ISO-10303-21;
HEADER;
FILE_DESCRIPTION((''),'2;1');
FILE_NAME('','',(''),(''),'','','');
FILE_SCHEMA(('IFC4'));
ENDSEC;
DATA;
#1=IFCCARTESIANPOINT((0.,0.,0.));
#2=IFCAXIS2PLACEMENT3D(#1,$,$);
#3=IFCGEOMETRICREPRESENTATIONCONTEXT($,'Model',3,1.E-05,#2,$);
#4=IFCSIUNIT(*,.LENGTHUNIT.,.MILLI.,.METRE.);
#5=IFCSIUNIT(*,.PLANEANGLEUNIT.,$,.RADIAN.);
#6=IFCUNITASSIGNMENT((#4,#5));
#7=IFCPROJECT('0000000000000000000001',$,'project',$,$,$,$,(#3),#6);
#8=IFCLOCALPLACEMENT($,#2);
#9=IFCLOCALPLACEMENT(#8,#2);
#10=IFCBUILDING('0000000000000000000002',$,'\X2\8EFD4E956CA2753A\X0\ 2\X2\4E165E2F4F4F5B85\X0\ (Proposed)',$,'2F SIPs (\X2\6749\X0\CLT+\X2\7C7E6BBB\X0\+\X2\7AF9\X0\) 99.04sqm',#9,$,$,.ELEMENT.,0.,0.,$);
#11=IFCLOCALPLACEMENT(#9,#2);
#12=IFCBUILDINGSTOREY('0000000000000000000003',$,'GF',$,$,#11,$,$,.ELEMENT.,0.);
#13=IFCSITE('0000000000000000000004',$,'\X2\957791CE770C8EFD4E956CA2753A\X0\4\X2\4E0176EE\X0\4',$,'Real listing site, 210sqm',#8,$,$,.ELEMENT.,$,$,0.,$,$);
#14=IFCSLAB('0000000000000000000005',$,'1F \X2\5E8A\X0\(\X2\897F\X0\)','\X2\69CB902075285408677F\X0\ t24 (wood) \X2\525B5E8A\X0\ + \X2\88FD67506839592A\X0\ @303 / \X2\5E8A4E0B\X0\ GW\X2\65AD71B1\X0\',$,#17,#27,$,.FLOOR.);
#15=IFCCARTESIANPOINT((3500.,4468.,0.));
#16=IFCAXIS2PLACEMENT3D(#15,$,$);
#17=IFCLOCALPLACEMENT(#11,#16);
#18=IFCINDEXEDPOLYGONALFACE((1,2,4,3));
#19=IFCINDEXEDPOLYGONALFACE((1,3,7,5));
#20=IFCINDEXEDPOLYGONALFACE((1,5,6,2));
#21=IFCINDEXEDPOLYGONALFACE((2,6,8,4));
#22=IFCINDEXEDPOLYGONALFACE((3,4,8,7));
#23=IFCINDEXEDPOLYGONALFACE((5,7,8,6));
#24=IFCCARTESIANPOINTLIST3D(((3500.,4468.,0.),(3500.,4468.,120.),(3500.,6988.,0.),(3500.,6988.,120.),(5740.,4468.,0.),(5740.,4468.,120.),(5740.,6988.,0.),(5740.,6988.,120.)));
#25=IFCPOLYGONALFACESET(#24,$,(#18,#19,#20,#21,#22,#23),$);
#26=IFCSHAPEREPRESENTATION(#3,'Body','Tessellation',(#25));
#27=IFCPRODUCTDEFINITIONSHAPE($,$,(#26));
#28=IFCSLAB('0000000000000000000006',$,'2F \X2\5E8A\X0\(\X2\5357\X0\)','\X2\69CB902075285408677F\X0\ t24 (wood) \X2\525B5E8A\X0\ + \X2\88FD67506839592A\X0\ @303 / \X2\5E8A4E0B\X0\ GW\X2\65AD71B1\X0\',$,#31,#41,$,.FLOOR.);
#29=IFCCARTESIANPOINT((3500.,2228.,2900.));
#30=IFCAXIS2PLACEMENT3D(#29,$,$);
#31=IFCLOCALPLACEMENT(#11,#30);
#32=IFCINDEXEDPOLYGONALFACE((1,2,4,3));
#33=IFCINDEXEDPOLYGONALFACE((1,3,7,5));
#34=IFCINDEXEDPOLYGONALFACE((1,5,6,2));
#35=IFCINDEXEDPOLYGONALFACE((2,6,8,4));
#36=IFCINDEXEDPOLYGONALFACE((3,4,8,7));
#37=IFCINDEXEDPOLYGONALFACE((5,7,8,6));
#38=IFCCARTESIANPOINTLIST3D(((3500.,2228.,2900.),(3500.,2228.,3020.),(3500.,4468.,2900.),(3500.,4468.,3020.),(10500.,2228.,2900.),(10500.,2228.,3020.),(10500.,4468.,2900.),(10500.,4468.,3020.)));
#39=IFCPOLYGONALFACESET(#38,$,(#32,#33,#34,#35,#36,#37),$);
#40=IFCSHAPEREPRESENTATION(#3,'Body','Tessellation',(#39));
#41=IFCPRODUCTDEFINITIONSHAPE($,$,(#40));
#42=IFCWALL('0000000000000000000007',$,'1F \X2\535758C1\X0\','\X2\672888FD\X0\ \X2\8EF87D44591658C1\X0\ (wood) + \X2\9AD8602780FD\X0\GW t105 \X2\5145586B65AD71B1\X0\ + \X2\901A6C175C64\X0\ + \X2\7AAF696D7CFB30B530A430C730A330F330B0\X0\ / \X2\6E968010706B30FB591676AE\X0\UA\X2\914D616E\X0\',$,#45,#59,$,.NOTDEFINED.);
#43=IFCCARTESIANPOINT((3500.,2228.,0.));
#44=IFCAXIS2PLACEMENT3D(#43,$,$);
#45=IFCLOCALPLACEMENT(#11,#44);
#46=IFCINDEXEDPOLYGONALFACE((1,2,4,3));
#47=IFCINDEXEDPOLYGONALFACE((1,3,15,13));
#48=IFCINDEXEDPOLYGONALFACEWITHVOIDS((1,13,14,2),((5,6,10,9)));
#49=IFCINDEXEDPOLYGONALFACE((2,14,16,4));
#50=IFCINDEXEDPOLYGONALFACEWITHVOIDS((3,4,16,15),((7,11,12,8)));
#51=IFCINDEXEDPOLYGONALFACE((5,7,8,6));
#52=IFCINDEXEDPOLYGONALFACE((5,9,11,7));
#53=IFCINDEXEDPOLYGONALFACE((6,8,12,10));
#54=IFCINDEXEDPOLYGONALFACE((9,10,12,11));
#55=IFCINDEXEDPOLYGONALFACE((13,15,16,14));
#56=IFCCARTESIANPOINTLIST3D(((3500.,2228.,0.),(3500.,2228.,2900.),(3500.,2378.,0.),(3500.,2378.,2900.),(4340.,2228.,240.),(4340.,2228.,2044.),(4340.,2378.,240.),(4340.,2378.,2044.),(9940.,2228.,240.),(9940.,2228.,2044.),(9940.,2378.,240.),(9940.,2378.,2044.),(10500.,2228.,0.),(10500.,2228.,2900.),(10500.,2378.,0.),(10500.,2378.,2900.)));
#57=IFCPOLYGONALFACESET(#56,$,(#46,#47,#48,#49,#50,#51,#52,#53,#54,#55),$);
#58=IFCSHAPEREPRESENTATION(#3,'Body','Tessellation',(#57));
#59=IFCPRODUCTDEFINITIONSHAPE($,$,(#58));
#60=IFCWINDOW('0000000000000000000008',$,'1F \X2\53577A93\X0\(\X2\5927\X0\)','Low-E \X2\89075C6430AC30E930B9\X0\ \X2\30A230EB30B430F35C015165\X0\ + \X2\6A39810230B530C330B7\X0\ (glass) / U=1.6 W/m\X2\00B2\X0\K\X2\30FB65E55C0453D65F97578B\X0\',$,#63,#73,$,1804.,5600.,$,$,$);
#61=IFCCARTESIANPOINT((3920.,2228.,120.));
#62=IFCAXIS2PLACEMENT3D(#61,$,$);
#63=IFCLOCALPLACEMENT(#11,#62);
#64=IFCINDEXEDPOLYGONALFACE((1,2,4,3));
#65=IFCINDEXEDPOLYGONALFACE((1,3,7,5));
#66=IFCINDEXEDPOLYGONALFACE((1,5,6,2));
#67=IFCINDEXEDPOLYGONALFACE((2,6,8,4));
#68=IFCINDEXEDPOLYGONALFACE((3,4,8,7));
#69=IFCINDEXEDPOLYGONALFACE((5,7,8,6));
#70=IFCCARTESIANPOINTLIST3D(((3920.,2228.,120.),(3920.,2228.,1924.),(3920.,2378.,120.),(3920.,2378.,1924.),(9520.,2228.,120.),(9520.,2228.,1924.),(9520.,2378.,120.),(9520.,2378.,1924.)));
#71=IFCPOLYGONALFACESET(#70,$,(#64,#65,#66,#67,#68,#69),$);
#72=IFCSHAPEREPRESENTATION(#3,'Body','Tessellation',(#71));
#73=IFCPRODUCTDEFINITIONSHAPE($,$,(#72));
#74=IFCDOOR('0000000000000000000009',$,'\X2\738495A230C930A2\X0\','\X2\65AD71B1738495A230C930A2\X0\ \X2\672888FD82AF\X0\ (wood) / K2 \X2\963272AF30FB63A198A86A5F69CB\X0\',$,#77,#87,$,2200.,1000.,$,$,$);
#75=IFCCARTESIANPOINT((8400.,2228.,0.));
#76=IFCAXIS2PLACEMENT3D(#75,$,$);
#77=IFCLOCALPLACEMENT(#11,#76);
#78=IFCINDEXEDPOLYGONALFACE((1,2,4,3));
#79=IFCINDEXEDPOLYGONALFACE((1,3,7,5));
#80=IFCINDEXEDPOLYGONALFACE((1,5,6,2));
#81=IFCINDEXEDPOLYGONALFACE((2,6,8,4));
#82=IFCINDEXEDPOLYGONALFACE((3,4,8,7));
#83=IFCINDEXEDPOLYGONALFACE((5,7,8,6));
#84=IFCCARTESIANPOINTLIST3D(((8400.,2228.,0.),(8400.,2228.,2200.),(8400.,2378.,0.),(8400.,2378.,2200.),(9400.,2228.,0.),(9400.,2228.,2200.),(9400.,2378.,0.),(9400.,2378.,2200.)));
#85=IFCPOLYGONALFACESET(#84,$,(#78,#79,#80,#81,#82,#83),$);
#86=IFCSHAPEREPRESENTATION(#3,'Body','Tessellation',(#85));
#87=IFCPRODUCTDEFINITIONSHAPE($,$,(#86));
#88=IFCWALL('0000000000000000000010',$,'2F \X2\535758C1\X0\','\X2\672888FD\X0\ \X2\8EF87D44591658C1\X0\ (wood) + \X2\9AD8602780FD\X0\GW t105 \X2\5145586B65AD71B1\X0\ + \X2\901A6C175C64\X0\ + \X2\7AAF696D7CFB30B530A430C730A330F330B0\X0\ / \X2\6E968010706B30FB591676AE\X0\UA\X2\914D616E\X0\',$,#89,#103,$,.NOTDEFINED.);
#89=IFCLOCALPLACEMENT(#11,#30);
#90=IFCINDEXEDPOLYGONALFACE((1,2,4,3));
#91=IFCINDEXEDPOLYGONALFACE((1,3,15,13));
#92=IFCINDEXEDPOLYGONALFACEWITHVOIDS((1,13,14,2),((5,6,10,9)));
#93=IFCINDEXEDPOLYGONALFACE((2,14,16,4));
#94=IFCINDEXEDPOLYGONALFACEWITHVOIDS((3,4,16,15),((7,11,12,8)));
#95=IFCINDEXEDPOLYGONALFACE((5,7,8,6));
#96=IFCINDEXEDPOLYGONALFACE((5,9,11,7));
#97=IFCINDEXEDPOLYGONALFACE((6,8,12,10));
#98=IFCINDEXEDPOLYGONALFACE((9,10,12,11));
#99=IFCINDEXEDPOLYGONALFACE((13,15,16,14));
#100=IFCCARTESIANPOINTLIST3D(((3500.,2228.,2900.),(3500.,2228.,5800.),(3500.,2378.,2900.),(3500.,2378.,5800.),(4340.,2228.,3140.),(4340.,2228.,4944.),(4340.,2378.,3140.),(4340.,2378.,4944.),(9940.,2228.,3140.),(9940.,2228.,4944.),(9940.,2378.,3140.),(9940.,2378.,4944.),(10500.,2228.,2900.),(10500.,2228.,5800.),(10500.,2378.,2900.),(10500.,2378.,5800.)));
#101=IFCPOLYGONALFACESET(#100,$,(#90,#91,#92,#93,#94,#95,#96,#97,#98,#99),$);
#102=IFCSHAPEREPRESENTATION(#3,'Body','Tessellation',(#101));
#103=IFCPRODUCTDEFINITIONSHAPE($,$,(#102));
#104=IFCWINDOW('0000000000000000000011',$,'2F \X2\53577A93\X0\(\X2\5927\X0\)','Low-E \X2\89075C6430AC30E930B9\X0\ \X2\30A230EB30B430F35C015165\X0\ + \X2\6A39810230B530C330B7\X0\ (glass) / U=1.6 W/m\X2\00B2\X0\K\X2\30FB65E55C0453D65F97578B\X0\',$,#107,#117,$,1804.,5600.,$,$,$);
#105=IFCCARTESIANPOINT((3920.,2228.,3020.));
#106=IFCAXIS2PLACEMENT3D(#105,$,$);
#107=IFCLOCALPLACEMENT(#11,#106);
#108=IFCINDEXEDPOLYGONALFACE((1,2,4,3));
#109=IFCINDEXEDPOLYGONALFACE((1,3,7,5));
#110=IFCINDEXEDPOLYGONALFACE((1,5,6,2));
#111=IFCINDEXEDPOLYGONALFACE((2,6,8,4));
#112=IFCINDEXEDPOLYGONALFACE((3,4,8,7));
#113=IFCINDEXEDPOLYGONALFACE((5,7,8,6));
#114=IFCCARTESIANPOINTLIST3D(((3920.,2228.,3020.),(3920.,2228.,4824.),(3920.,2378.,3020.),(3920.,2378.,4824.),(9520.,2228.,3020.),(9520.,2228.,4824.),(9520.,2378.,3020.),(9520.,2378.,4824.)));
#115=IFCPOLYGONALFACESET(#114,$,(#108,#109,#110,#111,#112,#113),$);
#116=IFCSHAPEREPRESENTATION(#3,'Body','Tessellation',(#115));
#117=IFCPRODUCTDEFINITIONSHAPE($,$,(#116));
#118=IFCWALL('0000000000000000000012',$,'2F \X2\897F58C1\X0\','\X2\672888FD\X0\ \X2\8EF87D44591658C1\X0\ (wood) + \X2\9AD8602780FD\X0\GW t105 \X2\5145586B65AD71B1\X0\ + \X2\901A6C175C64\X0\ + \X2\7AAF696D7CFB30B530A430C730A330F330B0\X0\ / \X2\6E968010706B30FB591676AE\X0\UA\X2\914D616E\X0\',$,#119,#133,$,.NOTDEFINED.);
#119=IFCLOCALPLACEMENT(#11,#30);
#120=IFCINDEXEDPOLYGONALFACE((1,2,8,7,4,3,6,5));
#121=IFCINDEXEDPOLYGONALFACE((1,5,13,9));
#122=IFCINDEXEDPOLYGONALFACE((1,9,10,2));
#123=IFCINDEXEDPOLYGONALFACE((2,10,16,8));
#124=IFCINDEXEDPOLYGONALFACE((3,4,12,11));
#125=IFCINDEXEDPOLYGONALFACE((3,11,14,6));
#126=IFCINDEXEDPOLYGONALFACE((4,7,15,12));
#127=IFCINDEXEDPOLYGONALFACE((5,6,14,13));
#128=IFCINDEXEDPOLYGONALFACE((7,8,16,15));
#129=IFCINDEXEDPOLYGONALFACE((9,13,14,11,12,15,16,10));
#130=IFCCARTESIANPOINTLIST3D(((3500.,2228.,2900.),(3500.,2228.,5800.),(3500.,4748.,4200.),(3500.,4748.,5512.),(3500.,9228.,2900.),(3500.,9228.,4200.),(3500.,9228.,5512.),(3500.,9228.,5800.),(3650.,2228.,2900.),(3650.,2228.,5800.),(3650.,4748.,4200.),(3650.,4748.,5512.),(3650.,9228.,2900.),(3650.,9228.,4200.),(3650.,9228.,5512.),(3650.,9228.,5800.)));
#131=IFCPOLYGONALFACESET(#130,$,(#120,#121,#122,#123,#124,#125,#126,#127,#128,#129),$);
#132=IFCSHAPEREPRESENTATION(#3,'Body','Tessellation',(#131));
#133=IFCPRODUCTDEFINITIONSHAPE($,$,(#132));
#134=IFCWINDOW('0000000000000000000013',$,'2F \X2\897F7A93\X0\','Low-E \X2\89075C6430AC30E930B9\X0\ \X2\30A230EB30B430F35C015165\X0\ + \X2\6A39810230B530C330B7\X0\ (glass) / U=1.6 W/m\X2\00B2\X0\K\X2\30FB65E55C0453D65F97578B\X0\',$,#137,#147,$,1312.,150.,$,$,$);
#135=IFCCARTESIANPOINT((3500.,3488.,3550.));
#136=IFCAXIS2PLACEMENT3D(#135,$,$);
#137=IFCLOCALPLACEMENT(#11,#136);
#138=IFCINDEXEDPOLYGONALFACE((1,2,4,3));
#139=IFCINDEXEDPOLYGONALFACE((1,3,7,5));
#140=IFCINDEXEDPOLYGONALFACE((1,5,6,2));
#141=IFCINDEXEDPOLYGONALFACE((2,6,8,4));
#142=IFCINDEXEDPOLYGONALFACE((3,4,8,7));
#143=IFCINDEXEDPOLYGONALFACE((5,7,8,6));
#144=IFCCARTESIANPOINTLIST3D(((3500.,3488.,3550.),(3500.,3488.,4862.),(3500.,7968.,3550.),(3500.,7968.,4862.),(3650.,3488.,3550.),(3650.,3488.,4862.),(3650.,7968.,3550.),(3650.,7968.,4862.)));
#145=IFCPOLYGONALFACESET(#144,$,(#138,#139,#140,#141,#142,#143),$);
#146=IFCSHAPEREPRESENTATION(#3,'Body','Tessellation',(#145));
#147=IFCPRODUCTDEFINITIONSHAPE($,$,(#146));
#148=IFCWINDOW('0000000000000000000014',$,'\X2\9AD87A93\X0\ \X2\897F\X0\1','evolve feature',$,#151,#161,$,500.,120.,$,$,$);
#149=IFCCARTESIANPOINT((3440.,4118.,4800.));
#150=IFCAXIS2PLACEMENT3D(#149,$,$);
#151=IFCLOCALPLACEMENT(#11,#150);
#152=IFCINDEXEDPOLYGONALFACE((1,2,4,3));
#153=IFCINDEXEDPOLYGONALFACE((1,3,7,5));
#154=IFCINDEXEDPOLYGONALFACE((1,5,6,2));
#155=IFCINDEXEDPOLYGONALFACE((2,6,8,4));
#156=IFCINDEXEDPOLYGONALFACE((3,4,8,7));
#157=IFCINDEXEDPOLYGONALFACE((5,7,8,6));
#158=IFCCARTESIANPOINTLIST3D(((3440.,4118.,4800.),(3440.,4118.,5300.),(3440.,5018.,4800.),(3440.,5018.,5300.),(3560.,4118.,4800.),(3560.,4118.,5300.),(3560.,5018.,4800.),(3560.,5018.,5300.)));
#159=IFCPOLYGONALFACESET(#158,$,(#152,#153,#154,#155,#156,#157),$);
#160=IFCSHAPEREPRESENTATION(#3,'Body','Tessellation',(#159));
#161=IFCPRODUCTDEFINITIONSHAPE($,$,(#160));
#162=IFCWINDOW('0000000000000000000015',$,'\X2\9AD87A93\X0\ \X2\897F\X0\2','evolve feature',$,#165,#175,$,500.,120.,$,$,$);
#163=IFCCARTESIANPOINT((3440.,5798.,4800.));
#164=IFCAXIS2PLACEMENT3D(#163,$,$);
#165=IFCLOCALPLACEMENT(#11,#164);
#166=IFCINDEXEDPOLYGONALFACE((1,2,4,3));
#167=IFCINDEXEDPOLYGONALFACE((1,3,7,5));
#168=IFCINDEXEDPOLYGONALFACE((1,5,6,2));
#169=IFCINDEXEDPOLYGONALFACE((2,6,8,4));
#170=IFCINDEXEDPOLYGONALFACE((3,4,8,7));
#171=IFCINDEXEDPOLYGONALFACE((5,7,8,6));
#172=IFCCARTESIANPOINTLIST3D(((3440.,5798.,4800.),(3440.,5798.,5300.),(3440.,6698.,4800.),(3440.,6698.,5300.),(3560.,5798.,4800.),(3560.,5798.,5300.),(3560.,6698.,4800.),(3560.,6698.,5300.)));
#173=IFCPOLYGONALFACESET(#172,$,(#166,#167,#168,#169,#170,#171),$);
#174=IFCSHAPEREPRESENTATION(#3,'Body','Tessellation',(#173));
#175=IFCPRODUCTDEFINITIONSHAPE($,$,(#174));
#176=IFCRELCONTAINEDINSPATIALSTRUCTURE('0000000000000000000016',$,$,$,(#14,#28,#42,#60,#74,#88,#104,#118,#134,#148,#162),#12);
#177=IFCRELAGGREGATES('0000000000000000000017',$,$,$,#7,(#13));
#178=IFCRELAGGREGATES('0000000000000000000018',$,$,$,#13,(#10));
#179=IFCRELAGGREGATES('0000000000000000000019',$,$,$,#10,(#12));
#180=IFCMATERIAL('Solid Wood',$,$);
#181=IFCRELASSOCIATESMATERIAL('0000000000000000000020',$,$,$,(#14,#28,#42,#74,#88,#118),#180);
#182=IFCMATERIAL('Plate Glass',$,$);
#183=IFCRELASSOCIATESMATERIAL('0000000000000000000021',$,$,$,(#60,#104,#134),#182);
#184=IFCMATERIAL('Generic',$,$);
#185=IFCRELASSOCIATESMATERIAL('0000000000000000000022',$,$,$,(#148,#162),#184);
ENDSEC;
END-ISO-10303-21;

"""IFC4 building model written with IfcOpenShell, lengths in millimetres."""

from ifc_helpers import new_model, si_unit, frame, frame_2d, origin, place, context, project, spatial, rectangle, extrude, material, element, fill, save


model = new_model("IFC4")

# Units and contexts
model_context = context("Model", 3, precision=1e-05, world=origin())
ifc_project = project(units=[si_unit("LENGTHUNIT", "METRE", prefix="MILLI"), si_unit("PLANEANGLEUNIT", "RADIAN")], contexts=[model_context])

# Site, building, storey
site_placement = place(None, origin())
site = spatial("IfcSite", under=ifc_project, at=site_placement, Name="長野県軽井沢町4丁目4", ObjectType="Real listing site, 210sqm", CompositionType="ELEMENT", RefElevation=0.0)
building_placement = place(site_placement, origin())
building = spatial("IfcBuilding", under=site, at=building_placement, Name="軽井沢町 2世帯住宅 (Proposed)", ObjectType="2F SIPs (杉CLT+籾殻+竹) 99.04sqm", CompositionType="ELEMENT", ElevationOfRefHeight=0.0, ElevationOfTerrain=0.0)
storey_placement = place(building_placement, origin())
storey = spatial("IfcBuildingStorey", under=building, at=storey_placement, Name="GF", CompositionType="ELEMENT", Elevation=0.0)

# Slabs
ifc_material_1 = material(Name="Solid Wood")
slab_1_placement = place(storey_placement, frame((3500.0, 4468.0, 0.0)))
element("IfcSlab", 1, at=slab_1_placement, inside=storey, material=ifc_material_1, Name="1F 床(西)", Description="構造用合板 t24 (wood) 剛床 + 製材根太 @303 / 床下 GW断熱", PredefinedType="FLOOR", context=model_context, shape_type="SweptSolid", body=[
    extrude(rectangle(XDim=2240.0, YDim=2520.0, at=frame_2d((1120.0, 1260.0))), frame((3500.0, 4468.0, 0.0)), (0.0, 0.0, 1.0), 120.0),
])
slab_2_placement = place(storey_placement, frame((3500.0, 2228.0, 2900.0)))
element("IfcSlab", 2, at=slab_2_placement, inside=storey, material=ifc_material_1, Name="2F 床(南)", Description="構造用合板 t24 (wood) 剛床 + 製材根太 @303 / 床下 GW断熱", PredefinedType="FLOOR", context=model_context, shape_type="SweptSolid", body=[
    extrude(rectangle(XDim=7000.0, YDim=2240.0, at=frame_2d((3500.0, 1120.0))), frame((3500.0, 2228.0, 2900.0)), (0.0, 0.0, 1.0), 120.0),
])
ifc_material_2 = material(Name="Generic")

# Wall, openings, window, door
wall_1_placement = place(storey_placement, frame((3500.0, 2228.0, 0.0)))
wall_1 = element("IfcWall", 3, at=wall_1_placement, inside=storey, material=ifc_material_1, Name="1F 南壁", Description="木製 軸組外壁 (wood) + 高性能GW t105 充填断熱 + 通気層 + 窯業系サイディング / 準耐火・外皮UA配慮", PredefinedType="NOTDEFINED", context=model_context, shape_type="SweptSolid", body=[
    extrude(rectangle(XDim=7000.0, YDim=150.0, at=frame_2d((3500.0, 75.0))), frame((3500.0, 2228.0, 0.0)), (0.0, 0.0, 1.0), 2900.0),
])
opening_1_placement = place(storey_placement, frame((3920.0, 2228.0, 120.0)))
opening_1 = element("IfcOpeningElement", 4, at=opening_1_placement, cuts=wall_1, PredefinedType="NOTDEFINED", context=model_context, shape_type="SweptSolid", body=[
    extrude(rectangle(XDim=5600.0, YDim=150.0, at=frame_2d((2800.0, 75.0))), frame((3920.0, 2228.0, 120.0)), (0.0, 0.0, 1.0), 1804.0),
])
opening_2_placement = place(storey_placement, frame((8400.0, 2228.0, 0.0)))
opening_2 = element("IfcOpeningElement", 5, at=opening_2_placement, cuts=wall_1, PredefinedType="NOTDEFINED", context=model_context, shape_type="SweptSolid", body=[
    extrude(rectangle(XDim=1000.0, YDim=150.0, at=frame_2d((500.0, 75.0))), frame((8400.0, 2228.0, 0.0)), (0.0, 0.0, 1.0), 2200.0),
])
ifc_material_3 = material(Name="Plate Glass")
window_1_placement = place(storey_placement, frame((3920.0, 2228.0, 120.0)))
window_1 = element("IfcWindow", 6, at=window_1_placement, inside=storey, material=ifc_material_3, Name="1F 南窓(大)", Description="Low-E 複層ガラス アルゴン封入 + 樹脂サッシ (glass) / U=1.6 W/m²K・日射取得型", OverallHeight=1804.0, OverallWidth=5600.0, context=model_context, shape_type="SweptSolid", body=[
    extrude(rectangle(XDim=5600.0, YDim=150.0, at=frame_2d((2800.0, 75.0))), frame((3920.0, 2228.0, 120.0)), (0.0, 0.0, 1.0), 1804.0),
])
fill(opening_1, window_1)
door_placement = place(storey_placement, frame((8400.0, 2228.0, 0.0)))
door = element("IfcDoor", 7, at=door_placement, inside=storey, material=ifc_material_1, Name="玄関ドア", Description="断熱玄関ドア 木製芯 (wood) / K2 防犯・採風機構", OverallHeight=2200.0, OverallWidth=1000.0, context=model_context, shape_type="SweptSolid", body=[
    extrude(rectangle(XDim=1000.0, YDim=150.0, at=frame_2d((500.0, 75.0))), frame((8400.0, 2228.0, 0.0)), (0.0, 0.0, 1.0), 2200.0),
])
fill(opening_2, door)

# Wall, opening, window
wall_2_placement = place(storey_placement, frame((3500.0, 2228.0, 2900.0)))
wall_2 = element("IfcWall", 8, at=wall_2_placement, inside=storey, material=ifc_material_1, Name="2F 南壁", Description="木製 軸組外壁 (wood) + 高性能GW t105 充填断熱 + 通気層 + 窯業系サイディング / 準耐火・外皮UA配慮", PredefinedType="NOTDEFINED", context=model_context, shape_type="SweptSolid", body=[
    extrude(rectangle(XDim=7000.0, YDim=150.0, at=frame_2d((3500.0, 75.0))), frame((3500.0, 2228.0, 2900.0)), (0.0, 0.0, 1.0), 2900.0),
])
opening_3_placement = place(storey_placement, frame((3920.0, 2228.0, 3020.0)))
opening_3 = element("IfcOpeningElement", 9, at=opening_3_placement, cuts=wall_2, PredefinedType="NOTDEFINED", context=model_context, shape_type="SweptSolid", body=[
    extrude(rectangle(XDim=5600.0, YDim=150.0, at=frame_2d((2800.0, 75.0))), frame((3920.0, 2228.0, 3020.0)), (0.0, 0.0, 1.0), 1804.0),
])
window_2_placement = place(storey_placement, frame((3920.0, 2228.0, 3020.0)))
window_2 = element("IfcWindow", 10, at=window_2_placement, inside=storey, material=ifc_material_3, Name="2F 南窓(大)", Description="Low-E 複層ガラス アルゴン封入 + 樹脂サッシ (glass) / U=1.6 W/m²K・日射取得型", OverallHeight=1804.0, OverallWidth=5600.0, context=model_context, shape_type="SweptSolid", body=[
    extrude(rectangle(XDim=5600.0, YDim=150.0, at=frame_2d((2800.0, 75.0))), frame((3920.0, 2228.0, 3020.0)), (0.0, 0.0, 1.0), 1804.0),
])
fill(opening_3, window_2)

# Wall, openings, windows
wall_3_placement = place(storey_placement, frame((3500.0, 2228.0, 2900.0)))
wall_3 = element("IfcWall", 11, at=wall_3_placement, inside=storey, material=ifc_material_1, Name="2F 西壁", Description="木製 軸組外壁 (wood) + 高性能GW t105 充填断熱 + 通気層 + 窯業系サイディング / 準耐火・外皮UA配慮", PredefinedType="NOTDEFINED", context=model_context, shape_type="SweptSolid", body=[
    extrude(rectangle(XDim=150.0, YDim=7000.0, at=frame_2d((75.0, 3500.0))), frame((3500.0, 2228.0, 2900.0)), (0.0, 0.0, 1.0), 2900.0),
])
opening_4_placement = place(storey_placement, frame((3500.0, 3488.0, 3550.0)))
opening_4 = element("IfcOpeningElement", 12, at=opening_4_placement, cuts=wall_3, PredefinedType="NOTDEFINED", context=model_context, shape_type="SweptSolid", body=[
    extrude(rectangle(XDim=150.0, YDim=4480.0, at=frame_2d((75.0, 2240.0))), frame((3500.0, 3488.0, 3550.0)), (0.0, 0.0, 1.0), 1312.0),
])
opening_5_placement = place(storey_placement, frame((3440.0, 4118.0, 4800.0)))
opening_5 = element("IfcOpeningElement", 13, at=opening_5_placement, cuts=wall_3, PredefinedType="NOTDEFINED", context=model_context, shape_type="SweptSolid", body=[
    extrude(rectangle(XDim=120.0, YDim=900.0, at=frame_2d((60.0, 450.0))), frame((3440.0, 4118.0, 4800.0)), (0.0, 0.0, 1.0), 500.0),
])
opening_6_placement = place(storey_placement, frame((3440.0, 5798.0, 4800.0)))
opening_6 = element("IfcOpeningElement", 14, at=opening_6_placement, cuts=wall_3, PredefinedType="NOTDEFINED", context=model_context, shape_type="SweptSolid", body=[
    extrude(rectangle(XDim=120.0, YDim=900.0, at=frame_2d((60.0, 450.0))), frame((3440.0, 5798.0, 4800.0)), (0.0, 0.0, 1.0), 500.0),
])
window_3_placement = place(storey_placement, frame((3500.0, 3488.0, 3550.0)))
window_3 = element("IfcWindow", 15, at=window_3_placement, inside=storey, material=ifc_material_3, Name="2F 西窓", Description="Low-E 複層ガラス アルゴン封入 + 樹脂サッシ (glass) / U=1.6 W/m²K・日射取得型", OverallHeight=1312.0, OverallWidth=150.0, context=model_context, shape_type="SweptSolid", body=[
    extrude(rectangle(XDim=150.0, YDim=4480.0, at=frame_2d((75.0, 2240.0))), frame((3500.0, 3488.0, 3550.0)), (0.0, 0.0, 1.0), 1312.0),
])
fill(opening_4, window_3)
window_4_placement = place(storey_placement, frame((3440.0, 4118.0, 4800.0)))
window_4 = element("IfcWindow", 16, at=window_4_placement, inside=storey, material=ifc_material_2, Name="高窓 西1", Description="evolve feature", OverallHeight=500.0, OverallWidth=120.0, context=model_context, shape_type="SweptSolid", body=[
    extrude(rectangle(XDim=120.0, YDim=900.0, at=frame_2d((60.0, 450.0))), frame((3440.0, 4118.0, 4800.0)), (0.0, 0.0, 1.0), 500.0),
])
fill(opening_5, window_4)
window_5_placement = place(storey_placement, frame((3440.0, 5798.0, 4800.0)))
window_5 = element("IfcWindow", 17, at=window_5_placement, inside=storey, material=ifc_material_2, Name="高窓 西2", Description="evolve feature", OverallHeight=500.0, OverallWidth=120.0, context=model_context, shape_type="SweptSolid", body=[
    extrude(rectangle(XDim=120.0, YDim=900.0, at=frame_2d((60.0, 450.0))), frame((3440.0, 5798.0, 4800.0)), (0.0, 0.0, 1.0), 500.0),
])
fill(opening_6, window_5)

save(model, "model.ifc")
